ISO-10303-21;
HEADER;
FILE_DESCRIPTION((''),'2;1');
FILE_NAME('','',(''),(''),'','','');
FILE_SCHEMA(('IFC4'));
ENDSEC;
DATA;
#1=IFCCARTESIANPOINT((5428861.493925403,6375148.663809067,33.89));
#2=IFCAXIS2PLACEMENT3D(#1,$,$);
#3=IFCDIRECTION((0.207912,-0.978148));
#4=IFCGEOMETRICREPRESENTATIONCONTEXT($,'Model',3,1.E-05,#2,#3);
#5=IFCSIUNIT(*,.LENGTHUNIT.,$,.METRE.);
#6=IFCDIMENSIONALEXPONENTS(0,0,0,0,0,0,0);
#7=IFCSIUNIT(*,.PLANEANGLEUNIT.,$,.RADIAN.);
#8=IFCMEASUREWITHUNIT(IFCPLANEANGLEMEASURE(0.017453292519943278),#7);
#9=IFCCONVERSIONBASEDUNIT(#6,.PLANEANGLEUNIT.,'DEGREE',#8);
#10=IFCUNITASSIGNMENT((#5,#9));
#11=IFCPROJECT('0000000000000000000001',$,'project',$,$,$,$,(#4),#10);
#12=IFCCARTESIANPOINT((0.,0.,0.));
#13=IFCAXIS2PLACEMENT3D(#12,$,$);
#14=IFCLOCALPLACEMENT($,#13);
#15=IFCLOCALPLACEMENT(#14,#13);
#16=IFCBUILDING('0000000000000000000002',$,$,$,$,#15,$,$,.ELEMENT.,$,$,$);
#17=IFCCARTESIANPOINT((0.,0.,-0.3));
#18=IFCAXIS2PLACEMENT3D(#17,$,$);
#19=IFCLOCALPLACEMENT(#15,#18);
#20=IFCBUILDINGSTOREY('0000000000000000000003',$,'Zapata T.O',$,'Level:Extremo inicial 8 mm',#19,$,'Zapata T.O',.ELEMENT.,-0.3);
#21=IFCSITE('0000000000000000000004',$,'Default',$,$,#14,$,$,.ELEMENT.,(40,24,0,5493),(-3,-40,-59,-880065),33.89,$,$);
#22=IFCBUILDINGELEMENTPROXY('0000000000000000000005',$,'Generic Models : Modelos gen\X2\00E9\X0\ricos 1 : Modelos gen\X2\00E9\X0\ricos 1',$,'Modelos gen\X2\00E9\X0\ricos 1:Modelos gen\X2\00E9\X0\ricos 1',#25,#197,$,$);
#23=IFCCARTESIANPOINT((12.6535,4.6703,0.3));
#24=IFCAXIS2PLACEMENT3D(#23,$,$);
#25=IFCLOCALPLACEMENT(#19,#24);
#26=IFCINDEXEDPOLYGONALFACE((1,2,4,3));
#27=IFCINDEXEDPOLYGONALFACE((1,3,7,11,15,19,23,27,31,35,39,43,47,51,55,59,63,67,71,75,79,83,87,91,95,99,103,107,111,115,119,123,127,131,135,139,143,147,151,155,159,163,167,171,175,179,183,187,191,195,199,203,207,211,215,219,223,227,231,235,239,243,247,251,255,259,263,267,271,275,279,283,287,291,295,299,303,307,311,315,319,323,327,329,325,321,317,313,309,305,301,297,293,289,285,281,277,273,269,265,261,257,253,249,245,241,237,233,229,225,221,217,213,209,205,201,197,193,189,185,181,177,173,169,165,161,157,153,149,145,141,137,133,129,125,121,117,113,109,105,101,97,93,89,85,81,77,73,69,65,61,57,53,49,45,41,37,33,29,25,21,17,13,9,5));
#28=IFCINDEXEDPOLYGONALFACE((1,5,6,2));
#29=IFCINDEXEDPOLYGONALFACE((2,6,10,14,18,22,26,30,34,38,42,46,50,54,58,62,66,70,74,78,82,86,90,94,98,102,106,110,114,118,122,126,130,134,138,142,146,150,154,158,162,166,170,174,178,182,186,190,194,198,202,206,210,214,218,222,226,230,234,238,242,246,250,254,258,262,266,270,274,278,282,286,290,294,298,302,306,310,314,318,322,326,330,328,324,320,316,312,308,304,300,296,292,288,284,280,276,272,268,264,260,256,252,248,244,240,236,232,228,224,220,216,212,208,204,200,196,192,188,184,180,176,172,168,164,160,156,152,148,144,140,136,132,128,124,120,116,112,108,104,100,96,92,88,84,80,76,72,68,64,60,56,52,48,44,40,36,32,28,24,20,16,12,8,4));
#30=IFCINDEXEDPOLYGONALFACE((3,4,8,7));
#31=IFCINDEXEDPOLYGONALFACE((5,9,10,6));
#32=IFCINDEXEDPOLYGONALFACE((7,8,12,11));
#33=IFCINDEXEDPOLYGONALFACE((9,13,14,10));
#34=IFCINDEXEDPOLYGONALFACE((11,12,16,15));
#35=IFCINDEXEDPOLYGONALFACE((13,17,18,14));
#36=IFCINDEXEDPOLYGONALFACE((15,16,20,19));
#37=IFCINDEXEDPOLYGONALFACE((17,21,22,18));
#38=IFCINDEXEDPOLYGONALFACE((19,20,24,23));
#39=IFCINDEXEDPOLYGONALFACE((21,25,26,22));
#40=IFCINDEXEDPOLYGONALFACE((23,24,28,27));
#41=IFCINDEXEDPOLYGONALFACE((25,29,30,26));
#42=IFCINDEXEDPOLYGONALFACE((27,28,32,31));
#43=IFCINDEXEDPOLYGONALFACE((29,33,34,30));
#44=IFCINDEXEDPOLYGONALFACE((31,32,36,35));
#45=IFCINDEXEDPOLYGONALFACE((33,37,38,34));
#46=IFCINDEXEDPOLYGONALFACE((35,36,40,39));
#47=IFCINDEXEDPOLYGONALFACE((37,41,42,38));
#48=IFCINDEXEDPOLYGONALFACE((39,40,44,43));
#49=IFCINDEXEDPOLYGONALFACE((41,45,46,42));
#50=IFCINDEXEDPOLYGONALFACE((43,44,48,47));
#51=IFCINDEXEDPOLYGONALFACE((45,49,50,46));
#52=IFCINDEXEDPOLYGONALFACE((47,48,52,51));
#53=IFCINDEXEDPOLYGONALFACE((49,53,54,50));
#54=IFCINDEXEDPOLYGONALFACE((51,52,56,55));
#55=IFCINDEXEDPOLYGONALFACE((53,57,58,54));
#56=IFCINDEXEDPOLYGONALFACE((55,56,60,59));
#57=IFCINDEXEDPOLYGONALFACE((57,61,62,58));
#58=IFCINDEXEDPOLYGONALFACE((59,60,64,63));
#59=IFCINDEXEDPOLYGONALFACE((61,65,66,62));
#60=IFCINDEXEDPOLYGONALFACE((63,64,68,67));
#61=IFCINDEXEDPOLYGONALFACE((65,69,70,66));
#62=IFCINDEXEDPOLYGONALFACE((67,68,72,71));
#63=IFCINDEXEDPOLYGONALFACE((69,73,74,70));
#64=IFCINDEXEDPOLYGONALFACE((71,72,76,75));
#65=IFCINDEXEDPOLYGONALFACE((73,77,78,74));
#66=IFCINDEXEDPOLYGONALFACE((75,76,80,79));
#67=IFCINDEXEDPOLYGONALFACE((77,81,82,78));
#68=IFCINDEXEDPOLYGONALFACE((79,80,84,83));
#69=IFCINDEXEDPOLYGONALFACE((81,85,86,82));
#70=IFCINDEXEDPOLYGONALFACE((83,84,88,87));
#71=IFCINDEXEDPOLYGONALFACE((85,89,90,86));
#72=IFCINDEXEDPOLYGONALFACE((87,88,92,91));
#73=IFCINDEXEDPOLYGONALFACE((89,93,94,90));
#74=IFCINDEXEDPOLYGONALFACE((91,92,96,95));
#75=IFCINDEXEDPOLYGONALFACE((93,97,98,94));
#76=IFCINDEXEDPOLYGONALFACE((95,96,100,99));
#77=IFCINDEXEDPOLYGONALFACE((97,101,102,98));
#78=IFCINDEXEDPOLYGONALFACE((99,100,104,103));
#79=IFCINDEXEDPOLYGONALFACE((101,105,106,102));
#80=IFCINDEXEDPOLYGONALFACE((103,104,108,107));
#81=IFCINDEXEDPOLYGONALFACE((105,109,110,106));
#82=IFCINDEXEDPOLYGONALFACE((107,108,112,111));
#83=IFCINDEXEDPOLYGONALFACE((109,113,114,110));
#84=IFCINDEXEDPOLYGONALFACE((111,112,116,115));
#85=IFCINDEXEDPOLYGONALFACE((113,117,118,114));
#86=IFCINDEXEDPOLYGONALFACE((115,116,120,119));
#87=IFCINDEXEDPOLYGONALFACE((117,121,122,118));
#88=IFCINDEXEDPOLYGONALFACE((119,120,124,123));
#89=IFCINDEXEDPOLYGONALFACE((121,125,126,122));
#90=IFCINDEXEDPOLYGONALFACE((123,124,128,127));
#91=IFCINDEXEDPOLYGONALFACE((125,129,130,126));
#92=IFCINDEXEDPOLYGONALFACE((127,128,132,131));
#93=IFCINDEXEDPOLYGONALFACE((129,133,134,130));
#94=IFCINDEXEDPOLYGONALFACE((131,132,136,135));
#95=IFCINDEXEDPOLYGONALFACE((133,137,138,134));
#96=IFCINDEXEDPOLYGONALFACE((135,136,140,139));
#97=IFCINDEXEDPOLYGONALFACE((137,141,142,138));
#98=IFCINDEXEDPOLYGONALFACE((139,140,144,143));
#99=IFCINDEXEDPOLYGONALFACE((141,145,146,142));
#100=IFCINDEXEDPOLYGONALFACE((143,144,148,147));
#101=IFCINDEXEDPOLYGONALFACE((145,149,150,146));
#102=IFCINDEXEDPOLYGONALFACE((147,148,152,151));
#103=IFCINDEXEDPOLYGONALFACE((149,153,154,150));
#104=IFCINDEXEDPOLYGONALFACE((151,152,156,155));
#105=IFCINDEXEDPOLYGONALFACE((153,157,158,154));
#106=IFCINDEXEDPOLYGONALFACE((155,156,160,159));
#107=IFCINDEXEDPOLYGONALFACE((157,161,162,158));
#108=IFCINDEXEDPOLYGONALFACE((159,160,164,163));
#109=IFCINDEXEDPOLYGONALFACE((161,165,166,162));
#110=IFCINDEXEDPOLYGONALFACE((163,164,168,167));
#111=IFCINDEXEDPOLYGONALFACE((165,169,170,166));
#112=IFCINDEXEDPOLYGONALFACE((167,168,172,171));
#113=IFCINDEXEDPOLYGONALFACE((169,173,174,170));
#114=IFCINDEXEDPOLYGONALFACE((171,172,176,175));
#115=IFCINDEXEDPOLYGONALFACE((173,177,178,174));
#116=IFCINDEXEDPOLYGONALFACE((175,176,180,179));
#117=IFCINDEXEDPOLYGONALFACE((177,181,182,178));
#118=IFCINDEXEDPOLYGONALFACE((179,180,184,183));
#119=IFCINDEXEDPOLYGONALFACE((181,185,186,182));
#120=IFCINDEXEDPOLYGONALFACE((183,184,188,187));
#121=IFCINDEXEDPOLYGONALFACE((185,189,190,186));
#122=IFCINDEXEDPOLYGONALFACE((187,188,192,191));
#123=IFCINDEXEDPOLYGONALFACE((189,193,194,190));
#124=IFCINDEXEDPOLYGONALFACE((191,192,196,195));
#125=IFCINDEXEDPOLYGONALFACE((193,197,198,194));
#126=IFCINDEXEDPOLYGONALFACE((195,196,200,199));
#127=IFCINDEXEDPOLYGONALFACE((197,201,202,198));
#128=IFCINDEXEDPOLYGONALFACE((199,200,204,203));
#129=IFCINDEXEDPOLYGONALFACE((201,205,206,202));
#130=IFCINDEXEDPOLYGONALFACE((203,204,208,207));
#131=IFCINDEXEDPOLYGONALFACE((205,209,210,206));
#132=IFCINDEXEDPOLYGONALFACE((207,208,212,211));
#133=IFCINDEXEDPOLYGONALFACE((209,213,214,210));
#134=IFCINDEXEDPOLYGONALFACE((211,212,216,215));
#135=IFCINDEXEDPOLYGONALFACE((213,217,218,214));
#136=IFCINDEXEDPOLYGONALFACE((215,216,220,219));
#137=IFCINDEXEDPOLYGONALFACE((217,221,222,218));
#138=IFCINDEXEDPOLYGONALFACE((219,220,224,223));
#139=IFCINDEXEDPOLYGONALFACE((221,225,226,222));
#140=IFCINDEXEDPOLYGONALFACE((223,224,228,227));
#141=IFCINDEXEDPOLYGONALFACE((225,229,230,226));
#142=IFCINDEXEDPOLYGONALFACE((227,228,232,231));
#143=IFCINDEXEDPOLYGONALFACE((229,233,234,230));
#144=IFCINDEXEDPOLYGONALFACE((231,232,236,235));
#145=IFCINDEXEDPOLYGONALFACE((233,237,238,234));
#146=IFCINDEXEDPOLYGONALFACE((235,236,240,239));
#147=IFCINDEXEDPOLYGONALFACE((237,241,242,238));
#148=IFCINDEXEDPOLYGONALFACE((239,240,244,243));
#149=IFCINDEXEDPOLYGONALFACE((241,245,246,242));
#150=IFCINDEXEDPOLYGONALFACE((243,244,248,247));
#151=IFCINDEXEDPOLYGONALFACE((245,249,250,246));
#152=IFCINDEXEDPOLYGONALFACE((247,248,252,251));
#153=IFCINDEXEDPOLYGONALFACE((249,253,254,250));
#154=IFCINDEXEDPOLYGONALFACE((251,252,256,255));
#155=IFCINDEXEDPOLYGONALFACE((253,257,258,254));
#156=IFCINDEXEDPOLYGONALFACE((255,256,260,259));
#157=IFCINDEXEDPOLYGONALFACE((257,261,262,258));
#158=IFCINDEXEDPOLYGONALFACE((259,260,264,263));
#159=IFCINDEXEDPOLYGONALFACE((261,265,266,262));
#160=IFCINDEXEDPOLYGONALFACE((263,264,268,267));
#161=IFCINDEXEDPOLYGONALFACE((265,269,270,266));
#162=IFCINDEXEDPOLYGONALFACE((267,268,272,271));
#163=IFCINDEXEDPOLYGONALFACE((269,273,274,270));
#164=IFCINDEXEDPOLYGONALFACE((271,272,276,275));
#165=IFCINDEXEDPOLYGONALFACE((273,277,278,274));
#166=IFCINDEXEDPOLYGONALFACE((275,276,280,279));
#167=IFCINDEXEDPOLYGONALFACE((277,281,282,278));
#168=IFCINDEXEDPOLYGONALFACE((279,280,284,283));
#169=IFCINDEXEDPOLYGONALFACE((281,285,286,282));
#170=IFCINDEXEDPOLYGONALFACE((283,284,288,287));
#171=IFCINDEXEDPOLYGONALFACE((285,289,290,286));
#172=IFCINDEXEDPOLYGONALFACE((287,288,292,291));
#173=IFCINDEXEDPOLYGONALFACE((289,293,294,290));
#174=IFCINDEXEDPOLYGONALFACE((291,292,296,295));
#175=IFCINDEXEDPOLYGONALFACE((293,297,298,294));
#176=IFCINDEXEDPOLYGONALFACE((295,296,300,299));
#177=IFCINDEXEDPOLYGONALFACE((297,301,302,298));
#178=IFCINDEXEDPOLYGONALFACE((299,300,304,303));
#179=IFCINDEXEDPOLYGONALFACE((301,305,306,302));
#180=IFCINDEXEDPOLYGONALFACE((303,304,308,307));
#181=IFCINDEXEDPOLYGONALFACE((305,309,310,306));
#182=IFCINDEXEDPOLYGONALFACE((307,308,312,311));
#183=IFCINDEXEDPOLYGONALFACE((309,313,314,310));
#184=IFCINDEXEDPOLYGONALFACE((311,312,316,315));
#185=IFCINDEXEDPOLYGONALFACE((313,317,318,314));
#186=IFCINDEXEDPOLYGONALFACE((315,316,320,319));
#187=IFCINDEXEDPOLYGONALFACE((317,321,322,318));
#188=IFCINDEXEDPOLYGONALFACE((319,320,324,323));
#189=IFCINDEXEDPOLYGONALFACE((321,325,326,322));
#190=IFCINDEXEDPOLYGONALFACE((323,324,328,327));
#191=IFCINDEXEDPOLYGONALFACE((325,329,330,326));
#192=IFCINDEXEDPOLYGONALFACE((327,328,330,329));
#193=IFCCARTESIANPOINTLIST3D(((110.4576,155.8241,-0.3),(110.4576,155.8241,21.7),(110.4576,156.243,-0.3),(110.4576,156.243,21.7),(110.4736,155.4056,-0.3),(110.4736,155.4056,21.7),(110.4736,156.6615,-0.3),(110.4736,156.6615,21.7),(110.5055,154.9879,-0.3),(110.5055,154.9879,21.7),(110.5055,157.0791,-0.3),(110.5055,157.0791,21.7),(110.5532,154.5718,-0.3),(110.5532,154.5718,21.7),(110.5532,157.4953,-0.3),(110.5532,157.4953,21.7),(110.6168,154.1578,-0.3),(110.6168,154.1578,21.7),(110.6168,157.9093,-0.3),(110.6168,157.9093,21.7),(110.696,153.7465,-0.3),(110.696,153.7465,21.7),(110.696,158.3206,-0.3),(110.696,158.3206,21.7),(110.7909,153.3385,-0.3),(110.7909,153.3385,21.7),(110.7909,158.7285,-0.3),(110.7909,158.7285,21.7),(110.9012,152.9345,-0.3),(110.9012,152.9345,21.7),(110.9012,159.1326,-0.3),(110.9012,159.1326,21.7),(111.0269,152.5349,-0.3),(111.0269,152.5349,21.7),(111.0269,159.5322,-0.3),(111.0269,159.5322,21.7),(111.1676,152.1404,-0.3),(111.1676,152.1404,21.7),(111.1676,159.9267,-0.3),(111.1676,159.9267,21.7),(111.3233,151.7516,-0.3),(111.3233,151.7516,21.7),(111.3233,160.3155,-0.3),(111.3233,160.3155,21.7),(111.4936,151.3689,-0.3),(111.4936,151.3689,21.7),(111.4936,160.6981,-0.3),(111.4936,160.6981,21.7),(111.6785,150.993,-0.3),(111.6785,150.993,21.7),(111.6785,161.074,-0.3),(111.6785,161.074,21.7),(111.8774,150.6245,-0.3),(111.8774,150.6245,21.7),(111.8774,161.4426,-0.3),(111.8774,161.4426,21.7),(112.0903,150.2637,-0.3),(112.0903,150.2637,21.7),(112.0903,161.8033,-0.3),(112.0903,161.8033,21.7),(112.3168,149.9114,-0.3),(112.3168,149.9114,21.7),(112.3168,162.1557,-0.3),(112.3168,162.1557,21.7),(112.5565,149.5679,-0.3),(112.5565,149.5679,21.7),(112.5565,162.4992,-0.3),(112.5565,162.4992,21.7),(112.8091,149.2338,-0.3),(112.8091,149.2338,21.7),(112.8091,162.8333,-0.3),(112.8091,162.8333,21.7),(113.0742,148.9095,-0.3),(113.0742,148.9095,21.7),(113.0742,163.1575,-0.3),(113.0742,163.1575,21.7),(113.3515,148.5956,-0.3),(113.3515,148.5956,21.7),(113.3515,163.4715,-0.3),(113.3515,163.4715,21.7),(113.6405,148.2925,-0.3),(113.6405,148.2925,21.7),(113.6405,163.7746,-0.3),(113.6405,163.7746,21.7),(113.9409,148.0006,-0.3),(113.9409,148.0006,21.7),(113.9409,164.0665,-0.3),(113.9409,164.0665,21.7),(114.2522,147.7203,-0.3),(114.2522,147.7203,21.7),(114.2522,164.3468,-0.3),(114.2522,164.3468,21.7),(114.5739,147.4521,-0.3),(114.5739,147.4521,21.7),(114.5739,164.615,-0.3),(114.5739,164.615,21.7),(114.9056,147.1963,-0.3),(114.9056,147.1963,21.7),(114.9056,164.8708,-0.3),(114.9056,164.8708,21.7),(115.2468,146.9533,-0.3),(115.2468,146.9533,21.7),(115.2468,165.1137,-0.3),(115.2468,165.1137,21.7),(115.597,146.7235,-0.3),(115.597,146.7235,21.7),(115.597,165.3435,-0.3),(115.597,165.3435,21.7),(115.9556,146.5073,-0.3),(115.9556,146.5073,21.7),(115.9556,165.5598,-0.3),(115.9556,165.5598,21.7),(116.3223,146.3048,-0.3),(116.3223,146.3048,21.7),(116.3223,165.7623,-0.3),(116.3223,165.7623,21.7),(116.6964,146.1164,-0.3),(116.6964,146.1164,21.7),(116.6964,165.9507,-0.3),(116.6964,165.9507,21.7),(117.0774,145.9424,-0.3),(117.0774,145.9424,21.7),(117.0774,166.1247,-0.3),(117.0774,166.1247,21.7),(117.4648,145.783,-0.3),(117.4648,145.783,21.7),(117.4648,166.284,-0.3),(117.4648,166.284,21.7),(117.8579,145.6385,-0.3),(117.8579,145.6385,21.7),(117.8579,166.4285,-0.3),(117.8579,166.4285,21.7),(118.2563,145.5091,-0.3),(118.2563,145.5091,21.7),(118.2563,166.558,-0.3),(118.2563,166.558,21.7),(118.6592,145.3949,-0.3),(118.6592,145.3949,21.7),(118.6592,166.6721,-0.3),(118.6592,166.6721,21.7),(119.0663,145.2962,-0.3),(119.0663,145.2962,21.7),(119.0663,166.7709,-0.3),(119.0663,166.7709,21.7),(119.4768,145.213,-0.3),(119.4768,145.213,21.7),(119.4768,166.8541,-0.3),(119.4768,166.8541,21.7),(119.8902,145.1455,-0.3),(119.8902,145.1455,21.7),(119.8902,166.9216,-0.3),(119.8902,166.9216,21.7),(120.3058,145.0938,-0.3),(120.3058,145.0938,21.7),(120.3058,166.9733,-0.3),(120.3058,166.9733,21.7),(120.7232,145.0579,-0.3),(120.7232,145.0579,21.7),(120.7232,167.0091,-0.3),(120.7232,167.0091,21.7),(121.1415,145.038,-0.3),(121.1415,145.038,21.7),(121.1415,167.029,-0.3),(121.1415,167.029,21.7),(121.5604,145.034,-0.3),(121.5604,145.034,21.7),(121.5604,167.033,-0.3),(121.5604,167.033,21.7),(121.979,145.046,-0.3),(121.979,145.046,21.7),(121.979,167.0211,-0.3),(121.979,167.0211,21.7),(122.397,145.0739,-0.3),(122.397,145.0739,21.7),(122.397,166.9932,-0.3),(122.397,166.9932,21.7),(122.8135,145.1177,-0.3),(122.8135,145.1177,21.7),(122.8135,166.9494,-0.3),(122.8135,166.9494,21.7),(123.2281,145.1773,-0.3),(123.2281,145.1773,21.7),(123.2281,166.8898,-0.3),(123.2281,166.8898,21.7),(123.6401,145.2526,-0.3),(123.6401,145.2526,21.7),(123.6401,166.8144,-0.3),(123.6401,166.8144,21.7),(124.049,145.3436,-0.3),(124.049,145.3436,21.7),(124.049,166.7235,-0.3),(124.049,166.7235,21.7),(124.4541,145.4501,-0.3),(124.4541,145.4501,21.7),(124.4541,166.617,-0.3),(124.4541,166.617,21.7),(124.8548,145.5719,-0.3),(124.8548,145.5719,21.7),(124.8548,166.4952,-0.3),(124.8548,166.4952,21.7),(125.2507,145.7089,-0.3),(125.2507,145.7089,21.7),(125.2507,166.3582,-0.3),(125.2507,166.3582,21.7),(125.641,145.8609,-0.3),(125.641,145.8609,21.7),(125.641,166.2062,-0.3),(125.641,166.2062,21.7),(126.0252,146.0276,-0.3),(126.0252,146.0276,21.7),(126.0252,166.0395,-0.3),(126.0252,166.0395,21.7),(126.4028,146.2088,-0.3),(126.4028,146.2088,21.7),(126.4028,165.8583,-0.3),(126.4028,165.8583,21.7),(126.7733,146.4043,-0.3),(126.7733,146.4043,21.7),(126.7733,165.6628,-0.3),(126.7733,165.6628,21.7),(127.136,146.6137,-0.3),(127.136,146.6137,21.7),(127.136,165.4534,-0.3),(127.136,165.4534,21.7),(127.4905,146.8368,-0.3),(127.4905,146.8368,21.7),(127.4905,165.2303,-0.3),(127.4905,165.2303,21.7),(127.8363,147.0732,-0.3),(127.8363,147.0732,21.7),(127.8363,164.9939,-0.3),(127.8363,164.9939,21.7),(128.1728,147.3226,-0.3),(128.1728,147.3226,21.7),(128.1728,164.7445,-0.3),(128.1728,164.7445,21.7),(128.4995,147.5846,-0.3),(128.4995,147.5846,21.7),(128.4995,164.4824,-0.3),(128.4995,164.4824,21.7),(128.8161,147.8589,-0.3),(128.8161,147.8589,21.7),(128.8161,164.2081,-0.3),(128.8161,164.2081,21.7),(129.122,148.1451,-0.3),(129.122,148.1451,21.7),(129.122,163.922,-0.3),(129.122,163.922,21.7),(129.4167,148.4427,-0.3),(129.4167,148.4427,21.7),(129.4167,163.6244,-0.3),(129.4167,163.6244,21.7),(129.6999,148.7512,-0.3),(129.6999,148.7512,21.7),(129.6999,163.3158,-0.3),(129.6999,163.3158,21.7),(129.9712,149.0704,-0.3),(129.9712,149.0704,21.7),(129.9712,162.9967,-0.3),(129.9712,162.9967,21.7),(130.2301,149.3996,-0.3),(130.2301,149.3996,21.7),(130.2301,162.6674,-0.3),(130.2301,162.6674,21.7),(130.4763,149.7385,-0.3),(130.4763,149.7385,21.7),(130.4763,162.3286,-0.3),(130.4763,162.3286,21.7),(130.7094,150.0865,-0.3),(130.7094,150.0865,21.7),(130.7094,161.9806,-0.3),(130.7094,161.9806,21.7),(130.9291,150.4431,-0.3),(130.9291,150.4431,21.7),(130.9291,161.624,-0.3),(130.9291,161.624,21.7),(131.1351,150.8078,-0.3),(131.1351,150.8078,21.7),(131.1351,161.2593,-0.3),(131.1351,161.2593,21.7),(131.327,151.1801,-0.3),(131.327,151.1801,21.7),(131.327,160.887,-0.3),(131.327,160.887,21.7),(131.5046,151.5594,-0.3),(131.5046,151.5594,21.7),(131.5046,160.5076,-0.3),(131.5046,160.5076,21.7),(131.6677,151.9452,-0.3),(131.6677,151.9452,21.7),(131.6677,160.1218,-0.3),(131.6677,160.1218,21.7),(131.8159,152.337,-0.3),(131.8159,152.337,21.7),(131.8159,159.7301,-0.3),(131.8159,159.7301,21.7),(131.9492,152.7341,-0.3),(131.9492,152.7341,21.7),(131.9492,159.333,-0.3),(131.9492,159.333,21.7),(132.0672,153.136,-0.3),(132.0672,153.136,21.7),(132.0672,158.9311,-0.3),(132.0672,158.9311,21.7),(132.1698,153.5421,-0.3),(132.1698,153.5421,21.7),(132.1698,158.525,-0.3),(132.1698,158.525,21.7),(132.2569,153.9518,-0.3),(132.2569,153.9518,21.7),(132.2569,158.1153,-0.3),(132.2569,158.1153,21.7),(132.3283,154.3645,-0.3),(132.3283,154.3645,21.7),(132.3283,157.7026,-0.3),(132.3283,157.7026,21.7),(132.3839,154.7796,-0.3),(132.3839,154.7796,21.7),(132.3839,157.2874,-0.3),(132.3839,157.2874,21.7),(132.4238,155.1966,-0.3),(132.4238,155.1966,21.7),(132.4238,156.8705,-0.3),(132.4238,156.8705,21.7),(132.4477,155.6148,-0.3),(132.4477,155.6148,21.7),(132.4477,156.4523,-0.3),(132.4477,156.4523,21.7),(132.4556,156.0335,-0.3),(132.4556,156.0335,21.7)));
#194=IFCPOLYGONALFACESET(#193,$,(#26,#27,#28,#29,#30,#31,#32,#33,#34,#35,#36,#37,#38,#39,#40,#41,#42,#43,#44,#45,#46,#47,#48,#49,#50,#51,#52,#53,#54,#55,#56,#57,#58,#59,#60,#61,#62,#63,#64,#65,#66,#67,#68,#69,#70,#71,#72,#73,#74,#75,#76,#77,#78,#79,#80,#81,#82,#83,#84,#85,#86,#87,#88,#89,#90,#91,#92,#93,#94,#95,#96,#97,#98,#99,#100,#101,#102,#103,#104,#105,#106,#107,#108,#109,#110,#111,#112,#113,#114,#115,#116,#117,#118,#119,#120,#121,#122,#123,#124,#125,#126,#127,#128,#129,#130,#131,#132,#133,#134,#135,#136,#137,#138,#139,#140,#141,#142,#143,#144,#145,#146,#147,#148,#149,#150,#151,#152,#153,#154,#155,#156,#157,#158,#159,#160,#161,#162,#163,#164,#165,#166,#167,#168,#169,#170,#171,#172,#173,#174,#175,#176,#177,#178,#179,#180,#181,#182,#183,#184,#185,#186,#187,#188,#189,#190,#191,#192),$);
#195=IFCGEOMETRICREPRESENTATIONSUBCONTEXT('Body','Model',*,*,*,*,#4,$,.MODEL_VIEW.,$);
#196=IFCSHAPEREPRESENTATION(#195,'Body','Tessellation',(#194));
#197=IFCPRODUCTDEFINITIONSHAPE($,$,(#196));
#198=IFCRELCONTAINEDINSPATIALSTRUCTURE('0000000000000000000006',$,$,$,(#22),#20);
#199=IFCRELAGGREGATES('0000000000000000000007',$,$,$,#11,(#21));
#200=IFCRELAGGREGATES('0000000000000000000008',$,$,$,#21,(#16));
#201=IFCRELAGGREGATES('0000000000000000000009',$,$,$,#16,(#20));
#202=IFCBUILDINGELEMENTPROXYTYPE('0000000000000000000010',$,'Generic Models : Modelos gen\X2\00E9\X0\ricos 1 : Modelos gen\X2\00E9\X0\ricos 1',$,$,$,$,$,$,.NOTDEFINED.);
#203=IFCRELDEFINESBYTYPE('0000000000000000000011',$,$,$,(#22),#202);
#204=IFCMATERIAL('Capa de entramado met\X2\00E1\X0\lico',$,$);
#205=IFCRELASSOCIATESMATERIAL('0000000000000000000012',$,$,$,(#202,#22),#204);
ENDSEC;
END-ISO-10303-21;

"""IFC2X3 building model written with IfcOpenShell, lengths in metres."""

from ifc_helpers import new_model, entity, si_unit, converted_unit, direction, frame, frame_2d, origin, place, context, subcontext, project, spatial, circle, extrude, source, transform, mapped, material, type_object, type_shapes, element, save


model = new_model("IFC2X3")

# Units and contexts
model_context = context("Model", 3, precision=1e-05, world=frame((5428861.493925403, 6375148.663809067, 33.89)), true_north=direction((0.207912, -0.978148)))
body_context = subcontext(model_context, "Body", "Model", "MODEL_VIEW")
ifc_project = project(units=[si_unit("LENGTHUNIT", "METRE"), converted_unit("PLANEANGLEUNIT", "DEGREE", entity("IfcPlaneAngleMeasure", 0.017453292519943278), si_unit("PLANEANGLEUNIT", "RADIAN"), dimensions=[0, 0, 0, 0, 0, 0, 0])], contexts=[model_context])

# Site, building, storey
site_placement = place(None, origin())
site = spatial("IfcSite", under=ifc_project, at=site_placement, Name="Default", CompositionType="ELEMENT", RefLatitude=(40, 24, 0, 5493), RefLongitude=(-3, -40, -59, -880065), RefElevation=33.89)
building_placement = place(site_placement, origin())
building = spatial("IfcBuilding", under=site, at=building_placement, CompositionType="ELEMENT")
storey_placement = place(building_placement, frame((0.0, 0.0, -0.3)))
storey = spatial("IfcBuildingStorey", under=building, at=storey_placement, Name="Zapata T.O", ObjectType="Level:Extremo inicial 8 mm", LongName="Zapata T.O", CompositionType="ELEMENT", Elevation=-0.3)

# Building element proxy
ifc_material = material(Name="Capa de entramado metálico")
building_element_proxy_type_1 = type_object("IfcBuildingElementProxyType", Name="Generic Models : Modelos genéricos 1 : Modelos genéricos 1", PredefinedType="NOTDEFINED", material=ifc_material)
shared_shape_1 = source(origin(), body_context, "Body", "SweptSolid", [
    extrude(circle(Radius=11.0, at=frame_2d((0.0, 0.0), x_axis=(1.0, 0.0))), frame((121.4556, 156.0335, -0.3)), (0.0, 0.0, 1.0), 22.0),
])
type_shapes(building_element_proxy_type_1, [shared_shape_1])
proxy_1_placement = place(storey_placement, frame((12.6535, 4.6703, 0.3)))
element("IfcBuildingElementProxy", 1, at=proxy_1_placement, inside=storey, type_object=building_element_proxy_type_1, material=ifc_material, Name="Generic Models : Modelos genéricos 1 : Modelos genéricos 1", ObjectType="Modelos genéricos 1:Modelos genéricos 1", context=body_context, shape_type="MappedRepresentation", body=[
    mapped(shared_shape_1, transform((0.0, 0.0, 0.0), scale=1.0)),
])

save(model, "model.ifc")
